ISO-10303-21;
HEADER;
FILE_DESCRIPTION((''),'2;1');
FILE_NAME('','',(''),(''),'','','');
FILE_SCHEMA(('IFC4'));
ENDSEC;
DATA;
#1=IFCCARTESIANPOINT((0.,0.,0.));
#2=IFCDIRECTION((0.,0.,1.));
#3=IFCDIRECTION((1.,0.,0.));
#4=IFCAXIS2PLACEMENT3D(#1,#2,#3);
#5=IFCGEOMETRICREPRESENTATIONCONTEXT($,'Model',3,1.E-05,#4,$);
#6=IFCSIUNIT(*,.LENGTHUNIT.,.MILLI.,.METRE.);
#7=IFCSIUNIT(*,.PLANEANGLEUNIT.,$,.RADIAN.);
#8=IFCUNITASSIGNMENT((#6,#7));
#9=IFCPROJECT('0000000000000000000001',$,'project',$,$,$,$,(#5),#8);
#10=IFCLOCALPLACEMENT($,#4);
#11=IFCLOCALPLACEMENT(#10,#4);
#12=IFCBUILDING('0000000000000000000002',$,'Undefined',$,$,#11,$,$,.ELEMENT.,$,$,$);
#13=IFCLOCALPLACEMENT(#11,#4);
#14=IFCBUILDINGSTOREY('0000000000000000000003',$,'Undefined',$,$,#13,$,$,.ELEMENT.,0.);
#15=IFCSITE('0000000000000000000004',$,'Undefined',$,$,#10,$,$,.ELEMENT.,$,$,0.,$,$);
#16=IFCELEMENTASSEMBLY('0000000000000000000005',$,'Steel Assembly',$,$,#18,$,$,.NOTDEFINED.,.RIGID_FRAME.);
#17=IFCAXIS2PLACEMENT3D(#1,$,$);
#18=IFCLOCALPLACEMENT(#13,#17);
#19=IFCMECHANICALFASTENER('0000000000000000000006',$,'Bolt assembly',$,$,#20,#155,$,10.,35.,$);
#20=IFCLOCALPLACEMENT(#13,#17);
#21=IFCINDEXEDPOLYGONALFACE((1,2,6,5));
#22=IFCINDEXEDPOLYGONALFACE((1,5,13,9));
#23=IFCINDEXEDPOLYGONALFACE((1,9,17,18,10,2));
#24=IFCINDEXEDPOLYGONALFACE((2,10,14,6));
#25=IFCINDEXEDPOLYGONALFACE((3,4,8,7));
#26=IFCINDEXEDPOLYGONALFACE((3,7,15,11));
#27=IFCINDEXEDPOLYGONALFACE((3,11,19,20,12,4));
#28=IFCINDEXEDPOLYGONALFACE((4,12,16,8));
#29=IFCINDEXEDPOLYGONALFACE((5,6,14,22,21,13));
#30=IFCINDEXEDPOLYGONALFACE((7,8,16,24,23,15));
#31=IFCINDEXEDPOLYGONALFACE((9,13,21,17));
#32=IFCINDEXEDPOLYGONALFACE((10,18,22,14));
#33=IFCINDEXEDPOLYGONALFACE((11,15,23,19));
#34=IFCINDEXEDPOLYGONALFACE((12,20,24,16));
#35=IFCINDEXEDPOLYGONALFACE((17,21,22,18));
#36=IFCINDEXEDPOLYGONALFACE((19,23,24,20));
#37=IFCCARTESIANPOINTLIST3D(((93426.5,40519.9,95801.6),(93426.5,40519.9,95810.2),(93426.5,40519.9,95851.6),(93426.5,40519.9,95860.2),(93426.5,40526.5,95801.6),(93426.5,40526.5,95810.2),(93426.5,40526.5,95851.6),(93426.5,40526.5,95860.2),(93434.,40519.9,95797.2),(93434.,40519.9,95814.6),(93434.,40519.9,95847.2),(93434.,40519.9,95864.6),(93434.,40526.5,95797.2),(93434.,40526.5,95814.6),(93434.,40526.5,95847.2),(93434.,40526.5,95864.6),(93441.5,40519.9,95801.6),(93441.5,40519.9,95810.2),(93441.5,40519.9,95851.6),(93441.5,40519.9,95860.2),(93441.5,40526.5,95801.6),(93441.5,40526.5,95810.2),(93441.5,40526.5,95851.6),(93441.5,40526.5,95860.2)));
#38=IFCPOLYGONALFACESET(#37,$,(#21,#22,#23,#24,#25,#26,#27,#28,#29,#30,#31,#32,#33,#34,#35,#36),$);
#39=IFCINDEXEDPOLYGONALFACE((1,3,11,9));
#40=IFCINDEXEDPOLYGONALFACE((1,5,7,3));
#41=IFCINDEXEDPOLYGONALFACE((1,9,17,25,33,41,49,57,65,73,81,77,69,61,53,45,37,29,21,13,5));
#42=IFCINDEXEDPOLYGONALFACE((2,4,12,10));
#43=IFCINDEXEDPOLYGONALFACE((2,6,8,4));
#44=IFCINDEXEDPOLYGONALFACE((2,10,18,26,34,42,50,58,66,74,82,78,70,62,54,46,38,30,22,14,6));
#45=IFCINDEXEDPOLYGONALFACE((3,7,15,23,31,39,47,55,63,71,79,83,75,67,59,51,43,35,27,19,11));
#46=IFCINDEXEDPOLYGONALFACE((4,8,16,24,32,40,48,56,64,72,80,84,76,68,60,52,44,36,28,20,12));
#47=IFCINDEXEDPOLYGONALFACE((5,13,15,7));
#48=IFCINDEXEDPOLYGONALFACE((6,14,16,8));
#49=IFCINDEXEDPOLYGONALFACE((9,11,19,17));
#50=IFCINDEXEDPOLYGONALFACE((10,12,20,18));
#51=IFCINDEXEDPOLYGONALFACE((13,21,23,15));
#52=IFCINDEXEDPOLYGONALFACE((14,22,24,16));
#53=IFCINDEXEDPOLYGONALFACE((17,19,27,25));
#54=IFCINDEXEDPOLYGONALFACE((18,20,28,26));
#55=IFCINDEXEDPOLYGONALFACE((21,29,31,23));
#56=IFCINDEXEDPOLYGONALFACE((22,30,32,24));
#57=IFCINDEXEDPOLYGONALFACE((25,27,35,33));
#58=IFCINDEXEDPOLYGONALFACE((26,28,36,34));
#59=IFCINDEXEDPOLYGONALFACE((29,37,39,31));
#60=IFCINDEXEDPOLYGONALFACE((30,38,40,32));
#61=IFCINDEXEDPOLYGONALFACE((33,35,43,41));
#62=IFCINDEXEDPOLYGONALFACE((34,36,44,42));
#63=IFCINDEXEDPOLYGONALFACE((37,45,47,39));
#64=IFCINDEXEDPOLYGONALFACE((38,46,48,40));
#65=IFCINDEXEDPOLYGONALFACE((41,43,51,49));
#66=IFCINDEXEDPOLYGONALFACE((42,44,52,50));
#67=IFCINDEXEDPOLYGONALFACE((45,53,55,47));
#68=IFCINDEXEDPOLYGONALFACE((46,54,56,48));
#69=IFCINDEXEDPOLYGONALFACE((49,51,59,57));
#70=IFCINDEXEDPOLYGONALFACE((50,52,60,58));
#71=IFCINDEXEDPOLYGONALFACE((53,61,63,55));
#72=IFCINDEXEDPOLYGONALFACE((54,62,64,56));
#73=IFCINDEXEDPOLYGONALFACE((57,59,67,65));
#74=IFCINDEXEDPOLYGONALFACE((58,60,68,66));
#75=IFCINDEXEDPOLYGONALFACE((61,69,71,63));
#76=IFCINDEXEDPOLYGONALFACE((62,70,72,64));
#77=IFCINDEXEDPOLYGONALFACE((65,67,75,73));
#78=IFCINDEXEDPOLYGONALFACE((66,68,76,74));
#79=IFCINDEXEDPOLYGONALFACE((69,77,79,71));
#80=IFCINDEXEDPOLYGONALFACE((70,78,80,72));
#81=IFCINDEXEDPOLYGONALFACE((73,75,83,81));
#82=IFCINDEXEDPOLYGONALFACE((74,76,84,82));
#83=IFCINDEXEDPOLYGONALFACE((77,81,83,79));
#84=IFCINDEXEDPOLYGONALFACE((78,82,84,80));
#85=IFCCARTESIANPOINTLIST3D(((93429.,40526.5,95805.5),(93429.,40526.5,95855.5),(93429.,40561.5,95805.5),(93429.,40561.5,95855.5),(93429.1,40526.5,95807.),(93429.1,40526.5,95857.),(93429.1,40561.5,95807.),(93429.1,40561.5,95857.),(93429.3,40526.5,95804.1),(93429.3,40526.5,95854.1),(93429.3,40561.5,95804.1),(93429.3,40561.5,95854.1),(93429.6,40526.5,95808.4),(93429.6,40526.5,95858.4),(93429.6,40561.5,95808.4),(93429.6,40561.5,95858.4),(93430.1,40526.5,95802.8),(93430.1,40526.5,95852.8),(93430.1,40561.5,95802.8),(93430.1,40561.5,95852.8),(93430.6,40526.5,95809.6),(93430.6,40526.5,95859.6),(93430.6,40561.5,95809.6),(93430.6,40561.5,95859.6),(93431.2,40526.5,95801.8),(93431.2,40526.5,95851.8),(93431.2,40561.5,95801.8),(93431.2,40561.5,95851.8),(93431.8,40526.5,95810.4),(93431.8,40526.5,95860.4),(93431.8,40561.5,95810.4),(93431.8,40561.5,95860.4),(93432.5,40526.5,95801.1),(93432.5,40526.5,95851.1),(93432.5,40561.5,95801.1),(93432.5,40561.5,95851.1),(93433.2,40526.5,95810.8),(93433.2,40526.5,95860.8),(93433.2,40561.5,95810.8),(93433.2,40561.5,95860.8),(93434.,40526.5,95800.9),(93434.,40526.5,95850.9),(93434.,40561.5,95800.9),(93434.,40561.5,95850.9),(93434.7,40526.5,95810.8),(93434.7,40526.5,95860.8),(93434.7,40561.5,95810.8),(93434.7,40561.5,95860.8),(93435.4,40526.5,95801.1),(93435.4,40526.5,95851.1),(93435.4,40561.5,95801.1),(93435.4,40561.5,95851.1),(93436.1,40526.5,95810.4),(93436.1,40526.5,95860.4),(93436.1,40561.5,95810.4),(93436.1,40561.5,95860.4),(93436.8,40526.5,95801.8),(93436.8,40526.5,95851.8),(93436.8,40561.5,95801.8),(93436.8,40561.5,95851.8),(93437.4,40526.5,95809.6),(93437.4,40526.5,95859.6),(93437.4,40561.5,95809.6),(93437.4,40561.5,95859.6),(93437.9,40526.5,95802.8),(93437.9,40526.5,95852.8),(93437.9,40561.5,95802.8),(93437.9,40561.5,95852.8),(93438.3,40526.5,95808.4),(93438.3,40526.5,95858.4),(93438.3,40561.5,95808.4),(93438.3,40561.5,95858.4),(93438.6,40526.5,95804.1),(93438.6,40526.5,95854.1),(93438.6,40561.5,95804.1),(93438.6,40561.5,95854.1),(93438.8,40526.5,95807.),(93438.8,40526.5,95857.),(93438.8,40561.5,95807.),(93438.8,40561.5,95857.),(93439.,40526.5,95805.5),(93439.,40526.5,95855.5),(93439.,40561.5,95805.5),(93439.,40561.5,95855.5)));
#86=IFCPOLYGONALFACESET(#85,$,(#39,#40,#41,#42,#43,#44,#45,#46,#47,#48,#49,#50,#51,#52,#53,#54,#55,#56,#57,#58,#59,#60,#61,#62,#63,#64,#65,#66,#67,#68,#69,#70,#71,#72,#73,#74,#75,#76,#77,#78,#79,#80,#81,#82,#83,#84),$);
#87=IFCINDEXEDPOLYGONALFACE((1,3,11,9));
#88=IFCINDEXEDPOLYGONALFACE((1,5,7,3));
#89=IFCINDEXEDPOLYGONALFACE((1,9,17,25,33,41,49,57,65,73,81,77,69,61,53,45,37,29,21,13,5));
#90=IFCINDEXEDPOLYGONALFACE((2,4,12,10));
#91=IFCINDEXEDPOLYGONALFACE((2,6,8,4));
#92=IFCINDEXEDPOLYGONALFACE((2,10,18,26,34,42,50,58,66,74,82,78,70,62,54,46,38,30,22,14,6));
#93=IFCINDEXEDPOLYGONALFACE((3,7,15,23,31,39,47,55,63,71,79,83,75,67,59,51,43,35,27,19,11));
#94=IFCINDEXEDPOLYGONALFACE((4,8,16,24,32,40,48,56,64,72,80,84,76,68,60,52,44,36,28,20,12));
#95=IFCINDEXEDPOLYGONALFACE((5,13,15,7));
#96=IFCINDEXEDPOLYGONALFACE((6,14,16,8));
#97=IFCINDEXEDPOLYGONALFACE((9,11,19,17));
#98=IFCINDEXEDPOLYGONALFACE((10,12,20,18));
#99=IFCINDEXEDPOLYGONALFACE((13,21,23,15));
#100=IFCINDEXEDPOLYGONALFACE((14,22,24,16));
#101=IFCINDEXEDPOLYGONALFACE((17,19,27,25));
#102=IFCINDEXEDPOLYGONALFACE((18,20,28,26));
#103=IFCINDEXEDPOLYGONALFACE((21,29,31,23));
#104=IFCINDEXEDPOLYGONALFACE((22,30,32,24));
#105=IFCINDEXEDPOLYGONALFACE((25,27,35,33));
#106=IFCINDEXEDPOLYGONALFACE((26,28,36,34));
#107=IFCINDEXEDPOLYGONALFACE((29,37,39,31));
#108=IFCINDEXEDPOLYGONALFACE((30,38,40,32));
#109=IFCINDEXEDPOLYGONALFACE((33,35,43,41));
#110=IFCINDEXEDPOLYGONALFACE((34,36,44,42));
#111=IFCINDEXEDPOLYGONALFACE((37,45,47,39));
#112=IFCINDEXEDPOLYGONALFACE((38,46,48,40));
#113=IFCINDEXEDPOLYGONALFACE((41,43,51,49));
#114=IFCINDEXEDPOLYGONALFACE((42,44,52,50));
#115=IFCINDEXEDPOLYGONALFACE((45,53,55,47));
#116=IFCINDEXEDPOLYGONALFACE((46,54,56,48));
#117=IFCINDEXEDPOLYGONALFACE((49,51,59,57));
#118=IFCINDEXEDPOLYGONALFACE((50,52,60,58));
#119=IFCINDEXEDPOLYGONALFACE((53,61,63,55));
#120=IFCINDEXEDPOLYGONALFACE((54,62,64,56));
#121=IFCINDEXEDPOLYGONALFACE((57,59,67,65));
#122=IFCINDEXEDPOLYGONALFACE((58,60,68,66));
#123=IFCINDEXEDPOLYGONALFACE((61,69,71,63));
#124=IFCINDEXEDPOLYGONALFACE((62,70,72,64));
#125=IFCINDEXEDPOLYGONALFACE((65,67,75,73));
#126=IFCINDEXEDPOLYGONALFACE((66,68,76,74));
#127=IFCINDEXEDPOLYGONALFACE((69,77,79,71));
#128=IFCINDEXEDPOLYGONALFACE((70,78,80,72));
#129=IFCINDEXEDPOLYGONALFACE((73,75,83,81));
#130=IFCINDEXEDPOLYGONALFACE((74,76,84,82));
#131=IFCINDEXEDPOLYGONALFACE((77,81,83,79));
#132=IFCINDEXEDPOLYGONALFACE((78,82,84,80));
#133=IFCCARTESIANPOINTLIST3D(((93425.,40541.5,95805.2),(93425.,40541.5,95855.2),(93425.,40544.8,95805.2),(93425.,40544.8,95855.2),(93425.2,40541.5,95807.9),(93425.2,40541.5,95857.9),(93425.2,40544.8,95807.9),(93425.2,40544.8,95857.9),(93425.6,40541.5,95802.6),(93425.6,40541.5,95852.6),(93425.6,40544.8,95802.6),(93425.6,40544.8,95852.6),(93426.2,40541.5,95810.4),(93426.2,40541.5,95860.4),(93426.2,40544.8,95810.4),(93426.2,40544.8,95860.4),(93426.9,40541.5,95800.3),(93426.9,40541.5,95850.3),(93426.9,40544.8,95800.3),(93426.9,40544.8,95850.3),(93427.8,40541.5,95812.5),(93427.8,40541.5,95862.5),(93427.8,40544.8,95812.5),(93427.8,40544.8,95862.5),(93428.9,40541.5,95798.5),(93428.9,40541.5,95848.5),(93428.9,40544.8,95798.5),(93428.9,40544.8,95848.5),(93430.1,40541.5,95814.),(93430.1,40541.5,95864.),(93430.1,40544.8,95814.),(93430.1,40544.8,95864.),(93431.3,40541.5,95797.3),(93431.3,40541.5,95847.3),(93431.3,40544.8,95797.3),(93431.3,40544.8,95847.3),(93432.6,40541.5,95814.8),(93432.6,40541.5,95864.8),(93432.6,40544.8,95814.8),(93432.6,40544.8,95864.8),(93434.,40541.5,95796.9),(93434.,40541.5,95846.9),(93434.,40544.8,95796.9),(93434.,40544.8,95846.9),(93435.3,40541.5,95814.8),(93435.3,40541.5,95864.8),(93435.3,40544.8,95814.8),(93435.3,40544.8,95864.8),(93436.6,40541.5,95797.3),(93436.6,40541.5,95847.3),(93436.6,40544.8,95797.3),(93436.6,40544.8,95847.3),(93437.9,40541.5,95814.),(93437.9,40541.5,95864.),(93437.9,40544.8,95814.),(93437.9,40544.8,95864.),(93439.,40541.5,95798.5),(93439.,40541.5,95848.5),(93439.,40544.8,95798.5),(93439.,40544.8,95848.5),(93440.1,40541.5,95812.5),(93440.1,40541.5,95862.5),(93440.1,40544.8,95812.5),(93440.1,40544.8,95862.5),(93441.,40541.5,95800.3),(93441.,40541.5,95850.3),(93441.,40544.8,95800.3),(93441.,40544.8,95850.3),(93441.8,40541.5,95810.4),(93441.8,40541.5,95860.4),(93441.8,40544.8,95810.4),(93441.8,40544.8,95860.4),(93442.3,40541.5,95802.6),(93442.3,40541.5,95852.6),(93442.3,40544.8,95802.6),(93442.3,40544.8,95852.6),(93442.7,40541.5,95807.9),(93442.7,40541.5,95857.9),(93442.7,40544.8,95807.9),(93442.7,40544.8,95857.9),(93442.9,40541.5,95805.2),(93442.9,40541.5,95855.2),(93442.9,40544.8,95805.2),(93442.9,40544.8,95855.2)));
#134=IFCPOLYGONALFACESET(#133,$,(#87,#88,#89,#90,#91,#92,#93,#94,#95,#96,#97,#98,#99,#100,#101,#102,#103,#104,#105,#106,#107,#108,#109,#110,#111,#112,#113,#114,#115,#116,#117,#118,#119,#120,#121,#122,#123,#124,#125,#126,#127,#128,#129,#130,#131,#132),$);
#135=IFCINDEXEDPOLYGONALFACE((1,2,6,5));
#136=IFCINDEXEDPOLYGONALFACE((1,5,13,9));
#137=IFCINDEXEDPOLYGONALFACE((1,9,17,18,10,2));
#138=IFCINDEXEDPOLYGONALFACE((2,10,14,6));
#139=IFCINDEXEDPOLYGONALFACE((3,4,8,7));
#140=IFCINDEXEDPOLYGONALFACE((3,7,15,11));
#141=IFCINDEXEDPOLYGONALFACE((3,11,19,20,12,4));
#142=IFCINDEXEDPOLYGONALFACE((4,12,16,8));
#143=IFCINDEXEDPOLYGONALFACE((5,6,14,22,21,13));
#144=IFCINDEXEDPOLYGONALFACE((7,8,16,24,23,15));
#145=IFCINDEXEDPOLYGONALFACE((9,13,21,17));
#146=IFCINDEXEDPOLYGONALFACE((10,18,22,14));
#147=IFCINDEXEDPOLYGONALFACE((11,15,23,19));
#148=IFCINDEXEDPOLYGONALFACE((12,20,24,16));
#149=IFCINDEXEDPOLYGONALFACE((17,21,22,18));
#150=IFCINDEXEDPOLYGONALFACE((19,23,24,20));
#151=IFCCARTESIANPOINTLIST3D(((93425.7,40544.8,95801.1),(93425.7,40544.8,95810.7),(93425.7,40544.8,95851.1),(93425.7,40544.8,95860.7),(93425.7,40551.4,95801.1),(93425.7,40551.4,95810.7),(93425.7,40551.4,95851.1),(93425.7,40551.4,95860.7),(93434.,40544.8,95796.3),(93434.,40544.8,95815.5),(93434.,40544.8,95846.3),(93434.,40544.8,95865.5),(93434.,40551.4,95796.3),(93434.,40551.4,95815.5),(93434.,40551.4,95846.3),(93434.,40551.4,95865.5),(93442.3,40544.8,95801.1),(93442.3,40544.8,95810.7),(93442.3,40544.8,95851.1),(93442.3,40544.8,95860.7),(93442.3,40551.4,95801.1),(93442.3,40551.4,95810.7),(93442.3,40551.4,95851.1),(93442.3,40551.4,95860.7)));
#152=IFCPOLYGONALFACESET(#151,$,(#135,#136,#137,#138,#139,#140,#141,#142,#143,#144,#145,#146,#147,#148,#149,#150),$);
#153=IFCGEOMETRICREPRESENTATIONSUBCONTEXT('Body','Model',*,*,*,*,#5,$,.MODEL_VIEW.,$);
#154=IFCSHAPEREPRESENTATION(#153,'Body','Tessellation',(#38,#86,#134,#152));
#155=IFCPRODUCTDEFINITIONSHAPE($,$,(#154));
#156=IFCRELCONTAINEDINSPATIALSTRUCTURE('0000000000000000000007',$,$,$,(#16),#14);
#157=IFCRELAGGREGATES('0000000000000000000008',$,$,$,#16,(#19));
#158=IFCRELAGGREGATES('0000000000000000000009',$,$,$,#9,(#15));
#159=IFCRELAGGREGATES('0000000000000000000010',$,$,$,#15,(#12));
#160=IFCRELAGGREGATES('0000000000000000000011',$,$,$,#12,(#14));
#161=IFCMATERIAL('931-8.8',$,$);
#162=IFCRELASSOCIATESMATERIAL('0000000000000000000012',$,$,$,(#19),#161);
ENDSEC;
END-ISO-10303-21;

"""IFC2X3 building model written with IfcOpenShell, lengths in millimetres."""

from ifc_helpers import new_model, si_unit, frame, origin_with_axes, origin_2d_with_axis, place, context, subcontext, project, spatial, polyline, circle, outline, extrude, source, transform, mapped, material, element, aggregate, save


model = new_model("IFC2X3")

# Units and contexts
model_context = context("Model", 3, precision=1e-05, world=origin_with_axes())
body_context = subcontext(model_context, "Body", "Model", "MODEL_VIEW")
ifc_project = project(units=[si_unit("LENGTHUNIT", "METRE", prefix="MILLI"), si_unit("PLANEANGLEUNIT", "RADIAN")], contexts=[model_context])

# Site, building, storey
site_placement = place(None, origin_with_axes())
site = spatial("IfcSite", under=ifc_project, at=site_placement, Name="Undefined", CompositionType="ELEMENT", RefElevation=0.0)
building_placement = place(site_placement, origin_with_axes())
building = spatial("IfcBuilding", under=site, at=building_placement, Name="Undefined", CompositionType="ELEMENT")
storey_placement = place(building_placement, origin_with_axes())
storey = spatial("IfcBuildingStorey", under=building, at=storey_placement, Name="Undefined", CompositionType="ELEMENT", Elevation=0.0)

# Element assembly, mechanical fastener
assembly_1_placement = place(storey_placement, origin_with_axes())
assembly_1 = element("IfcElementAssembly", 1, at=assembly_1_placement, inside=storey, Name="Steel Assembly", AssemblyPlace="NOTDEFINED", PredefinedType="RIGID_FRAME")
ifc_material_1 = material(Name="931-8.8")
shared_shape_1 = source(origin_with_axes(), body_context, "Body", "SweptSolid", [
    extrude(outline(polyline([(8.7, 0.0), (4.3, 7.5), (-4.3, 7.5), (-8.7, 0.0), (-4.3, -7.5), (4.3, -7.5), (8.7, 0.0)])), frame((0.0, -16.6, 0.0), z_axis=(0.0, 1.0, 0.0), x_axis=(1.0, 0.0, 0.0)), (0.0, 0.0, 1.0), 6.6),
    extrude(circle(Radius=5.0, at=origin_2d_with_axis()), frame((0.0, -10.0, 0.0), z_axis=(0.0, 1.0, 0.0), x_axis=(1.0, 0.0, 0.0)), (0.0, 0.0, 1.0), 35.0),
    extrude(circle(Radius=9.0, at=origin_2d_with_axis()), frame((0.0, 5.0, 0.0), z_axis=(0.0, 1.0, 0.0), x_axis=(1.0, 0.0, 0.0)), (0.0, 0.0, 1.0), 3.3),
    extrude(outline(polyline([(9.6, 0.0), (4.8, 8.3), (-4.8, 8.3), (-9.6, 0.0), (-4.8, -8.3), (4.8, -8.3), (9.6, 0.0)])), frame((0.0, 8.3, 0.0), z_axis=(0.0, 1.0, 0.0), x_axis=(1.0, 0.0, 0.0)), (0.0, 0.0, 1.0), 6.6),
])
mechanical_fastener_1_placement = place(assembly_1_placement, frame((93434.0, 40536.5, 95855.9), z_axis=(1.0, 0.0, 0.0), x_axis=(0.0, 0.0, -1.0)))
mechanical_fastener_1 = element("IfcMechanicalFastener", 2, at=mechanical_fastener_1_placement, material=ifc_material_1, Name="Bolt assembly", NominalDiameter=10.0, NominalLength=35.0, context=body_context, shape_type="MappedRepresentation", body=[
    mapped(shared_shape_1, transform((0.0, 0.0, 0.0))),
    mapped(shared_shape_1, transform((50.0, 0.0, 0.0))),
])

aggregate(assembly_1, [mechanical_fastener_1])

save(model, "model.ifc")
